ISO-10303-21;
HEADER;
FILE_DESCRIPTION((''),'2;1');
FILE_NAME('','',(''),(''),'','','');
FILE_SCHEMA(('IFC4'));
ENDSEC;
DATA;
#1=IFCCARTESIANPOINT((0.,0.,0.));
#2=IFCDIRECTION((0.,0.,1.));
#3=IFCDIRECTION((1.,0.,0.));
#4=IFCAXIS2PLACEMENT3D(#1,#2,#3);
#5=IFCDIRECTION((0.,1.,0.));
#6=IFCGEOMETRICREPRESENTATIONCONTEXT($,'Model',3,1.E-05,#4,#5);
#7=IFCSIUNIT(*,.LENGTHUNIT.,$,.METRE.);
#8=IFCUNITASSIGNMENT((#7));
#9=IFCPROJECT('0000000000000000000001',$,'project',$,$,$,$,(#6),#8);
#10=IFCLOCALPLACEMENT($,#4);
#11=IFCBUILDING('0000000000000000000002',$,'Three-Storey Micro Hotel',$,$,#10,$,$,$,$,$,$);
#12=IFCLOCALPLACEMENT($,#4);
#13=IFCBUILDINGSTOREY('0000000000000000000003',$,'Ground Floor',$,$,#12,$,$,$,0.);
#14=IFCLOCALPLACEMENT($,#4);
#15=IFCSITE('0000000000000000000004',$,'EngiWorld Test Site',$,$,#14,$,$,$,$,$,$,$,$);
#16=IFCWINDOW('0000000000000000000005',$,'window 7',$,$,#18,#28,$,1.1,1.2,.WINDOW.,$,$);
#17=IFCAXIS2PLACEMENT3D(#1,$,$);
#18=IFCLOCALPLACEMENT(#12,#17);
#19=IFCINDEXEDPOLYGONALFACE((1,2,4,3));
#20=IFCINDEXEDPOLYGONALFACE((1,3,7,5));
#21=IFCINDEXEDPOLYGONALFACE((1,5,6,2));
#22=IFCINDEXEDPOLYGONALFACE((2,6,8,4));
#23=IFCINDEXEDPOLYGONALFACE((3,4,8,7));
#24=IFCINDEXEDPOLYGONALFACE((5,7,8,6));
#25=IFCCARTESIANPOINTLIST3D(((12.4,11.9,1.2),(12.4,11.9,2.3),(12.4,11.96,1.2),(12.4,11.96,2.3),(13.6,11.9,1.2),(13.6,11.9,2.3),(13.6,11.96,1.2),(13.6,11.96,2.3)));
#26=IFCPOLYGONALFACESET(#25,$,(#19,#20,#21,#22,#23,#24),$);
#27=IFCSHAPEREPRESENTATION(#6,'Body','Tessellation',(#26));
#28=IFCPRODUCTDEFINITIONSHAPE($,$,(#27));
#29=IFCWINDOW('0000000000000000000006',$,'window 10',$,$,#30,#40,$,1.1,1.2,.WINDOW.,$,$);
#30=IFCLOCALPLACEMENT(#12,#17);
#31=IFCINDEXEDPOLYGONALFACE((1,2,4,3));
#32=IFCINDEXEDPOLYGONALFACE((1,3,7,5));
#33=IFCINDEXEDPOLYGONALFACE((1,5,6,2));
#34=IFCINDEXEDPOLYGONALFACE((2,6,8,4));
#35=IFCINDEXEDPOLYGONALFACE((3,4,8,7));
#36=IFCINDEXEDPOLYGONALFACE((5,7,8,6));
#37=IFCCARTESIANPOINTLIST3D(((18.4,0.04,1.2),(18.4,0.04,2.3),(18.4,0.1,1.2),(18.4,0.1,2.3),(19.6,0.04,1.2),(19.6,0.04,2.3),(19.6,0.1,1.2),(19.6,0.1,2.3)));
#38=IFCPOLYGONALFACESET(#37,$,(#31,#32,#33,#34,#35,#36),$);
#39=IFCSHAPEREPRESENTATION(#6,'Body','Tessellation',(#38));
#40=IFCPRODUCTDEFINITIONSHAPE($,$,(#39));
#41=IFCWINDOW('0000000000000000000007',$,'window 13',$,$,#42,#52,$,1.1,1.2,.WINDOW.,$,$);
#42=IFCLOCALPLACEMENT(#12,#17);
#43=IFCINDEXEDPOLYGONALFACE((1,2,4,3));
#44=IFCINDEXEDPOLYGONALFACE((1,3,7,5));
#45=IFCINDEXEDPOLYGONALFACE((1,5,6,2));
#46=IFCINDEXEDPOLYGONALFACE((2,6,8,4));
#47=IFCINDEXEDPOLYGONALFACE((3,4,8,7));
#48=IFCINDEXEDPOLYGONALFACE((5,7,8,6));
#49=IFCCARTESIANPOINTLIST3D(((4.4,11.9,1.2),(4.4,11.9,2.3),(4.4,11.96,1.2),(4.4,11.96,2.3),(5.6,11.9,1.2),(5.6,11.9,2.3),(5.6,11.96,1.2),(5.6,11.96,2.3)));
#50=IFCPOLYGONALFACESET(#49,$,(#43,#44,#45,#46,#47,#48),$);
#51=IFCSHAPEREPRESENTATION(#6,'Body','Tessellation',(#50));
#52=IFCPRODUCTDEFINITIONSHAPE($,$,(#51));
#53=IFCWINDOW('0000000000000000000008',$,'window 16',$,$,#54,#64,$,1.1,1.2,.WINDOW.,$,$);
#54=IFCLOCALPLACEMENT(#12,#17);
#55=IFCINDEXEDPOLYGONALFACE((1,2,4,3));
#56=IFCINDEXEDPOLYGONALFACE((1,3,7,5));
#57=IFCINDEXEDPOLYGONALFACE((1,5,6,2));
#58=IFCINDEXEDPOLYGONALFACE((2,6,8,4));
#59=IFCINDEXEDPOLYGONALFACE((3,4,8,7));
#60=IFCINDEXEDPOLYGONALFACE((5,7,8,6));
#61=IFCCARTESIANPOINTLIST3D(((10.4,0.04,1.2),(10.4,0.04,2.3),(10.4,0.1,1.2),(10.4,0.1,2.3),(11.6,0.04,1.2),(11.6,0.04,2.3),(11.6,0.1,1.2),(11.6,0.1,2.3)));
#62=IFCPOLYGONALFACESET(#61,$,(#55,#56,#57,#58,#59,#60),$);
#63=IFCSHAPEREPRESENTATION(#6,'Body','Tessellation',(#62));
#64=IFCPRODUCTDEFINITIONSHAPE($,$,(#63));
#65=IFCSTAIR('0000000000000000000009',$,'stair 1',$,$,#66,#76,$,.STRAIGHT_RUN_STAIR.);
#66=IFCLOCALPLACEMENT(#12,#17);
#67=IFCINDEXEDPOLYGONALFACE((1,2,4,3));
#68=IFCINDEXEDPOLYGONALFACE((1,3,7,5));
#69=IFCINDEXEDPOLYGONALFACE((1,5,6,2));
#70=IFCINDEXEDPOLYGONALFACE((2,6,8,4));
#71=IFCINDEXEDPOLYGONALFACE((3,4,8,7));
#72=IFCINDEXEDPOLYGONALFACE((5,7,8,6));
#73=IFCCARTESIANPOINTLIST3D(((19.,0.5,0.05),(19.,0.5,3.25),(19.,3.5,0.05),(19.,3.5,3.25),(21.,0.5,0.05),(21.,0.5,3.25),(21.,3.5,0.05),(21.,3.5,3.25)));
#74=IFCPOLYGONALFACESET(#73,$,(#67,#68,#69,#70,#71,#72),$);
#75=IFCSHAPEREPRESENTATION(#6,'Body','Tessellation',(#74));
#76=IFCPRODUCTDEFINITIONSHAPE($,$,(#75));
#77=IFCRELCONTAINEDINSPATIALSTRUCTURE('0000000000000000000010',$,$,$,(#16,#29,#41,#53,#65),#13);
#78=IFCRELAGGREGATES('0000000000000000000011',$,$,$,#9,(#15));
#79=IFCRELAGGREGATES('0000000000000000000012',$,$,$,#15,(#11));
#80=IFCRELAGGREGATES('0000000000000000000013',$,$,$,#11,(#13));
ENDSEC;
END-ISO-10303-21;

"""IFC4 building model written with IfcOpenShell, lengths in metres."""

from ifc_helpers import new_model, si_unit, direction, frame, origin_with_axes, origin_2d_with_axis, place, context, project, spatial, rectangle, extrude, element, save


model = new_model("IFC4")

# Units and contexts
model_context = context("Model", 3, precision=1e-05, world=origin_with_axes(), true_north=direction((0.0, 1.0, 0.0)))
ifc_project = project(units=[si_unit("LENGTHUNIT", "METRE")], contexts=[model_context])

# Site, building, storey
site_placement = place(None, origin_with_axes())
site = spatial("IfcSite", under=ifc_project, at=site_placement, Name="EngiWorld Test Site")
building_placement = place(None, origin_with_axes())
building = spatial("IfcBuilding", under=site, at=building_placement, Name="Three-Storey Micro Hotel")
storey_placement = place(None, origin_with_axes())
storey = spatial("IfcBuildingStorey", under=building, at=storey_placement, Name="Ground Floor", Elevation=0.0)

# Windows
for number, where, z_axis, x_axis, name in (
    (1, (13.0, 11.93, 1.2), (0.0, 0.0, 1.0), (1.0, 0.0, 0.0), "window 7"),
    (2, (19.0, 0.07, 1.2), (0.0, 0.0, 1.0), (1.0, 0.0, 0.0), "window 10"),
    (3, (5.0, 11.93, 1.2), (0.0, 0.0, 1.0), (1.0, 0.0, 0.0), "window 13"),
    (4, (11.0, 0.07, 1.2), (0.0, 0.0, 1.0), (1.0, 0.0, 0.0), "window 16"),
):
    element("IfcWindow", number, at=place(None, frame(where, z_axis=z_axis, x_axis=x_axis)), inside=storey, Name=name, OverallHeight=1.1, OverallWidth=1.2, PredefinedType="WINDOW", context=model_context, shape_type="SweptSolid", body=[
        extrude(rectangle(XDim=1.2, YDim=0.06, at=origin_2d_with_axis()), origin_with_axes(), (0.0, 0.0, 1.0), 1.1),
    ])

# Stair
stair_placement = place(None, frame((20.0, 2.0, 0.05), z_axis=(0.0, 0.0, 1.0), x_axis=(1.0, 0.0, 0.0)))
element("IfcStair", 5, at=stair_placement, inside=storey, Name="stair 1", PredefinedType="STRAIGHT_RUN_STAIR", context=model_context, shape_type="SweptSolid", body=[
    extrude(rectangle(XDim=2.0, YDim=3.0, at=origin_2d_with_axis()), origin_with_axes(), (0.0, 0.0, 1.0), 3.2),
])

save(model, "model.ifc")
